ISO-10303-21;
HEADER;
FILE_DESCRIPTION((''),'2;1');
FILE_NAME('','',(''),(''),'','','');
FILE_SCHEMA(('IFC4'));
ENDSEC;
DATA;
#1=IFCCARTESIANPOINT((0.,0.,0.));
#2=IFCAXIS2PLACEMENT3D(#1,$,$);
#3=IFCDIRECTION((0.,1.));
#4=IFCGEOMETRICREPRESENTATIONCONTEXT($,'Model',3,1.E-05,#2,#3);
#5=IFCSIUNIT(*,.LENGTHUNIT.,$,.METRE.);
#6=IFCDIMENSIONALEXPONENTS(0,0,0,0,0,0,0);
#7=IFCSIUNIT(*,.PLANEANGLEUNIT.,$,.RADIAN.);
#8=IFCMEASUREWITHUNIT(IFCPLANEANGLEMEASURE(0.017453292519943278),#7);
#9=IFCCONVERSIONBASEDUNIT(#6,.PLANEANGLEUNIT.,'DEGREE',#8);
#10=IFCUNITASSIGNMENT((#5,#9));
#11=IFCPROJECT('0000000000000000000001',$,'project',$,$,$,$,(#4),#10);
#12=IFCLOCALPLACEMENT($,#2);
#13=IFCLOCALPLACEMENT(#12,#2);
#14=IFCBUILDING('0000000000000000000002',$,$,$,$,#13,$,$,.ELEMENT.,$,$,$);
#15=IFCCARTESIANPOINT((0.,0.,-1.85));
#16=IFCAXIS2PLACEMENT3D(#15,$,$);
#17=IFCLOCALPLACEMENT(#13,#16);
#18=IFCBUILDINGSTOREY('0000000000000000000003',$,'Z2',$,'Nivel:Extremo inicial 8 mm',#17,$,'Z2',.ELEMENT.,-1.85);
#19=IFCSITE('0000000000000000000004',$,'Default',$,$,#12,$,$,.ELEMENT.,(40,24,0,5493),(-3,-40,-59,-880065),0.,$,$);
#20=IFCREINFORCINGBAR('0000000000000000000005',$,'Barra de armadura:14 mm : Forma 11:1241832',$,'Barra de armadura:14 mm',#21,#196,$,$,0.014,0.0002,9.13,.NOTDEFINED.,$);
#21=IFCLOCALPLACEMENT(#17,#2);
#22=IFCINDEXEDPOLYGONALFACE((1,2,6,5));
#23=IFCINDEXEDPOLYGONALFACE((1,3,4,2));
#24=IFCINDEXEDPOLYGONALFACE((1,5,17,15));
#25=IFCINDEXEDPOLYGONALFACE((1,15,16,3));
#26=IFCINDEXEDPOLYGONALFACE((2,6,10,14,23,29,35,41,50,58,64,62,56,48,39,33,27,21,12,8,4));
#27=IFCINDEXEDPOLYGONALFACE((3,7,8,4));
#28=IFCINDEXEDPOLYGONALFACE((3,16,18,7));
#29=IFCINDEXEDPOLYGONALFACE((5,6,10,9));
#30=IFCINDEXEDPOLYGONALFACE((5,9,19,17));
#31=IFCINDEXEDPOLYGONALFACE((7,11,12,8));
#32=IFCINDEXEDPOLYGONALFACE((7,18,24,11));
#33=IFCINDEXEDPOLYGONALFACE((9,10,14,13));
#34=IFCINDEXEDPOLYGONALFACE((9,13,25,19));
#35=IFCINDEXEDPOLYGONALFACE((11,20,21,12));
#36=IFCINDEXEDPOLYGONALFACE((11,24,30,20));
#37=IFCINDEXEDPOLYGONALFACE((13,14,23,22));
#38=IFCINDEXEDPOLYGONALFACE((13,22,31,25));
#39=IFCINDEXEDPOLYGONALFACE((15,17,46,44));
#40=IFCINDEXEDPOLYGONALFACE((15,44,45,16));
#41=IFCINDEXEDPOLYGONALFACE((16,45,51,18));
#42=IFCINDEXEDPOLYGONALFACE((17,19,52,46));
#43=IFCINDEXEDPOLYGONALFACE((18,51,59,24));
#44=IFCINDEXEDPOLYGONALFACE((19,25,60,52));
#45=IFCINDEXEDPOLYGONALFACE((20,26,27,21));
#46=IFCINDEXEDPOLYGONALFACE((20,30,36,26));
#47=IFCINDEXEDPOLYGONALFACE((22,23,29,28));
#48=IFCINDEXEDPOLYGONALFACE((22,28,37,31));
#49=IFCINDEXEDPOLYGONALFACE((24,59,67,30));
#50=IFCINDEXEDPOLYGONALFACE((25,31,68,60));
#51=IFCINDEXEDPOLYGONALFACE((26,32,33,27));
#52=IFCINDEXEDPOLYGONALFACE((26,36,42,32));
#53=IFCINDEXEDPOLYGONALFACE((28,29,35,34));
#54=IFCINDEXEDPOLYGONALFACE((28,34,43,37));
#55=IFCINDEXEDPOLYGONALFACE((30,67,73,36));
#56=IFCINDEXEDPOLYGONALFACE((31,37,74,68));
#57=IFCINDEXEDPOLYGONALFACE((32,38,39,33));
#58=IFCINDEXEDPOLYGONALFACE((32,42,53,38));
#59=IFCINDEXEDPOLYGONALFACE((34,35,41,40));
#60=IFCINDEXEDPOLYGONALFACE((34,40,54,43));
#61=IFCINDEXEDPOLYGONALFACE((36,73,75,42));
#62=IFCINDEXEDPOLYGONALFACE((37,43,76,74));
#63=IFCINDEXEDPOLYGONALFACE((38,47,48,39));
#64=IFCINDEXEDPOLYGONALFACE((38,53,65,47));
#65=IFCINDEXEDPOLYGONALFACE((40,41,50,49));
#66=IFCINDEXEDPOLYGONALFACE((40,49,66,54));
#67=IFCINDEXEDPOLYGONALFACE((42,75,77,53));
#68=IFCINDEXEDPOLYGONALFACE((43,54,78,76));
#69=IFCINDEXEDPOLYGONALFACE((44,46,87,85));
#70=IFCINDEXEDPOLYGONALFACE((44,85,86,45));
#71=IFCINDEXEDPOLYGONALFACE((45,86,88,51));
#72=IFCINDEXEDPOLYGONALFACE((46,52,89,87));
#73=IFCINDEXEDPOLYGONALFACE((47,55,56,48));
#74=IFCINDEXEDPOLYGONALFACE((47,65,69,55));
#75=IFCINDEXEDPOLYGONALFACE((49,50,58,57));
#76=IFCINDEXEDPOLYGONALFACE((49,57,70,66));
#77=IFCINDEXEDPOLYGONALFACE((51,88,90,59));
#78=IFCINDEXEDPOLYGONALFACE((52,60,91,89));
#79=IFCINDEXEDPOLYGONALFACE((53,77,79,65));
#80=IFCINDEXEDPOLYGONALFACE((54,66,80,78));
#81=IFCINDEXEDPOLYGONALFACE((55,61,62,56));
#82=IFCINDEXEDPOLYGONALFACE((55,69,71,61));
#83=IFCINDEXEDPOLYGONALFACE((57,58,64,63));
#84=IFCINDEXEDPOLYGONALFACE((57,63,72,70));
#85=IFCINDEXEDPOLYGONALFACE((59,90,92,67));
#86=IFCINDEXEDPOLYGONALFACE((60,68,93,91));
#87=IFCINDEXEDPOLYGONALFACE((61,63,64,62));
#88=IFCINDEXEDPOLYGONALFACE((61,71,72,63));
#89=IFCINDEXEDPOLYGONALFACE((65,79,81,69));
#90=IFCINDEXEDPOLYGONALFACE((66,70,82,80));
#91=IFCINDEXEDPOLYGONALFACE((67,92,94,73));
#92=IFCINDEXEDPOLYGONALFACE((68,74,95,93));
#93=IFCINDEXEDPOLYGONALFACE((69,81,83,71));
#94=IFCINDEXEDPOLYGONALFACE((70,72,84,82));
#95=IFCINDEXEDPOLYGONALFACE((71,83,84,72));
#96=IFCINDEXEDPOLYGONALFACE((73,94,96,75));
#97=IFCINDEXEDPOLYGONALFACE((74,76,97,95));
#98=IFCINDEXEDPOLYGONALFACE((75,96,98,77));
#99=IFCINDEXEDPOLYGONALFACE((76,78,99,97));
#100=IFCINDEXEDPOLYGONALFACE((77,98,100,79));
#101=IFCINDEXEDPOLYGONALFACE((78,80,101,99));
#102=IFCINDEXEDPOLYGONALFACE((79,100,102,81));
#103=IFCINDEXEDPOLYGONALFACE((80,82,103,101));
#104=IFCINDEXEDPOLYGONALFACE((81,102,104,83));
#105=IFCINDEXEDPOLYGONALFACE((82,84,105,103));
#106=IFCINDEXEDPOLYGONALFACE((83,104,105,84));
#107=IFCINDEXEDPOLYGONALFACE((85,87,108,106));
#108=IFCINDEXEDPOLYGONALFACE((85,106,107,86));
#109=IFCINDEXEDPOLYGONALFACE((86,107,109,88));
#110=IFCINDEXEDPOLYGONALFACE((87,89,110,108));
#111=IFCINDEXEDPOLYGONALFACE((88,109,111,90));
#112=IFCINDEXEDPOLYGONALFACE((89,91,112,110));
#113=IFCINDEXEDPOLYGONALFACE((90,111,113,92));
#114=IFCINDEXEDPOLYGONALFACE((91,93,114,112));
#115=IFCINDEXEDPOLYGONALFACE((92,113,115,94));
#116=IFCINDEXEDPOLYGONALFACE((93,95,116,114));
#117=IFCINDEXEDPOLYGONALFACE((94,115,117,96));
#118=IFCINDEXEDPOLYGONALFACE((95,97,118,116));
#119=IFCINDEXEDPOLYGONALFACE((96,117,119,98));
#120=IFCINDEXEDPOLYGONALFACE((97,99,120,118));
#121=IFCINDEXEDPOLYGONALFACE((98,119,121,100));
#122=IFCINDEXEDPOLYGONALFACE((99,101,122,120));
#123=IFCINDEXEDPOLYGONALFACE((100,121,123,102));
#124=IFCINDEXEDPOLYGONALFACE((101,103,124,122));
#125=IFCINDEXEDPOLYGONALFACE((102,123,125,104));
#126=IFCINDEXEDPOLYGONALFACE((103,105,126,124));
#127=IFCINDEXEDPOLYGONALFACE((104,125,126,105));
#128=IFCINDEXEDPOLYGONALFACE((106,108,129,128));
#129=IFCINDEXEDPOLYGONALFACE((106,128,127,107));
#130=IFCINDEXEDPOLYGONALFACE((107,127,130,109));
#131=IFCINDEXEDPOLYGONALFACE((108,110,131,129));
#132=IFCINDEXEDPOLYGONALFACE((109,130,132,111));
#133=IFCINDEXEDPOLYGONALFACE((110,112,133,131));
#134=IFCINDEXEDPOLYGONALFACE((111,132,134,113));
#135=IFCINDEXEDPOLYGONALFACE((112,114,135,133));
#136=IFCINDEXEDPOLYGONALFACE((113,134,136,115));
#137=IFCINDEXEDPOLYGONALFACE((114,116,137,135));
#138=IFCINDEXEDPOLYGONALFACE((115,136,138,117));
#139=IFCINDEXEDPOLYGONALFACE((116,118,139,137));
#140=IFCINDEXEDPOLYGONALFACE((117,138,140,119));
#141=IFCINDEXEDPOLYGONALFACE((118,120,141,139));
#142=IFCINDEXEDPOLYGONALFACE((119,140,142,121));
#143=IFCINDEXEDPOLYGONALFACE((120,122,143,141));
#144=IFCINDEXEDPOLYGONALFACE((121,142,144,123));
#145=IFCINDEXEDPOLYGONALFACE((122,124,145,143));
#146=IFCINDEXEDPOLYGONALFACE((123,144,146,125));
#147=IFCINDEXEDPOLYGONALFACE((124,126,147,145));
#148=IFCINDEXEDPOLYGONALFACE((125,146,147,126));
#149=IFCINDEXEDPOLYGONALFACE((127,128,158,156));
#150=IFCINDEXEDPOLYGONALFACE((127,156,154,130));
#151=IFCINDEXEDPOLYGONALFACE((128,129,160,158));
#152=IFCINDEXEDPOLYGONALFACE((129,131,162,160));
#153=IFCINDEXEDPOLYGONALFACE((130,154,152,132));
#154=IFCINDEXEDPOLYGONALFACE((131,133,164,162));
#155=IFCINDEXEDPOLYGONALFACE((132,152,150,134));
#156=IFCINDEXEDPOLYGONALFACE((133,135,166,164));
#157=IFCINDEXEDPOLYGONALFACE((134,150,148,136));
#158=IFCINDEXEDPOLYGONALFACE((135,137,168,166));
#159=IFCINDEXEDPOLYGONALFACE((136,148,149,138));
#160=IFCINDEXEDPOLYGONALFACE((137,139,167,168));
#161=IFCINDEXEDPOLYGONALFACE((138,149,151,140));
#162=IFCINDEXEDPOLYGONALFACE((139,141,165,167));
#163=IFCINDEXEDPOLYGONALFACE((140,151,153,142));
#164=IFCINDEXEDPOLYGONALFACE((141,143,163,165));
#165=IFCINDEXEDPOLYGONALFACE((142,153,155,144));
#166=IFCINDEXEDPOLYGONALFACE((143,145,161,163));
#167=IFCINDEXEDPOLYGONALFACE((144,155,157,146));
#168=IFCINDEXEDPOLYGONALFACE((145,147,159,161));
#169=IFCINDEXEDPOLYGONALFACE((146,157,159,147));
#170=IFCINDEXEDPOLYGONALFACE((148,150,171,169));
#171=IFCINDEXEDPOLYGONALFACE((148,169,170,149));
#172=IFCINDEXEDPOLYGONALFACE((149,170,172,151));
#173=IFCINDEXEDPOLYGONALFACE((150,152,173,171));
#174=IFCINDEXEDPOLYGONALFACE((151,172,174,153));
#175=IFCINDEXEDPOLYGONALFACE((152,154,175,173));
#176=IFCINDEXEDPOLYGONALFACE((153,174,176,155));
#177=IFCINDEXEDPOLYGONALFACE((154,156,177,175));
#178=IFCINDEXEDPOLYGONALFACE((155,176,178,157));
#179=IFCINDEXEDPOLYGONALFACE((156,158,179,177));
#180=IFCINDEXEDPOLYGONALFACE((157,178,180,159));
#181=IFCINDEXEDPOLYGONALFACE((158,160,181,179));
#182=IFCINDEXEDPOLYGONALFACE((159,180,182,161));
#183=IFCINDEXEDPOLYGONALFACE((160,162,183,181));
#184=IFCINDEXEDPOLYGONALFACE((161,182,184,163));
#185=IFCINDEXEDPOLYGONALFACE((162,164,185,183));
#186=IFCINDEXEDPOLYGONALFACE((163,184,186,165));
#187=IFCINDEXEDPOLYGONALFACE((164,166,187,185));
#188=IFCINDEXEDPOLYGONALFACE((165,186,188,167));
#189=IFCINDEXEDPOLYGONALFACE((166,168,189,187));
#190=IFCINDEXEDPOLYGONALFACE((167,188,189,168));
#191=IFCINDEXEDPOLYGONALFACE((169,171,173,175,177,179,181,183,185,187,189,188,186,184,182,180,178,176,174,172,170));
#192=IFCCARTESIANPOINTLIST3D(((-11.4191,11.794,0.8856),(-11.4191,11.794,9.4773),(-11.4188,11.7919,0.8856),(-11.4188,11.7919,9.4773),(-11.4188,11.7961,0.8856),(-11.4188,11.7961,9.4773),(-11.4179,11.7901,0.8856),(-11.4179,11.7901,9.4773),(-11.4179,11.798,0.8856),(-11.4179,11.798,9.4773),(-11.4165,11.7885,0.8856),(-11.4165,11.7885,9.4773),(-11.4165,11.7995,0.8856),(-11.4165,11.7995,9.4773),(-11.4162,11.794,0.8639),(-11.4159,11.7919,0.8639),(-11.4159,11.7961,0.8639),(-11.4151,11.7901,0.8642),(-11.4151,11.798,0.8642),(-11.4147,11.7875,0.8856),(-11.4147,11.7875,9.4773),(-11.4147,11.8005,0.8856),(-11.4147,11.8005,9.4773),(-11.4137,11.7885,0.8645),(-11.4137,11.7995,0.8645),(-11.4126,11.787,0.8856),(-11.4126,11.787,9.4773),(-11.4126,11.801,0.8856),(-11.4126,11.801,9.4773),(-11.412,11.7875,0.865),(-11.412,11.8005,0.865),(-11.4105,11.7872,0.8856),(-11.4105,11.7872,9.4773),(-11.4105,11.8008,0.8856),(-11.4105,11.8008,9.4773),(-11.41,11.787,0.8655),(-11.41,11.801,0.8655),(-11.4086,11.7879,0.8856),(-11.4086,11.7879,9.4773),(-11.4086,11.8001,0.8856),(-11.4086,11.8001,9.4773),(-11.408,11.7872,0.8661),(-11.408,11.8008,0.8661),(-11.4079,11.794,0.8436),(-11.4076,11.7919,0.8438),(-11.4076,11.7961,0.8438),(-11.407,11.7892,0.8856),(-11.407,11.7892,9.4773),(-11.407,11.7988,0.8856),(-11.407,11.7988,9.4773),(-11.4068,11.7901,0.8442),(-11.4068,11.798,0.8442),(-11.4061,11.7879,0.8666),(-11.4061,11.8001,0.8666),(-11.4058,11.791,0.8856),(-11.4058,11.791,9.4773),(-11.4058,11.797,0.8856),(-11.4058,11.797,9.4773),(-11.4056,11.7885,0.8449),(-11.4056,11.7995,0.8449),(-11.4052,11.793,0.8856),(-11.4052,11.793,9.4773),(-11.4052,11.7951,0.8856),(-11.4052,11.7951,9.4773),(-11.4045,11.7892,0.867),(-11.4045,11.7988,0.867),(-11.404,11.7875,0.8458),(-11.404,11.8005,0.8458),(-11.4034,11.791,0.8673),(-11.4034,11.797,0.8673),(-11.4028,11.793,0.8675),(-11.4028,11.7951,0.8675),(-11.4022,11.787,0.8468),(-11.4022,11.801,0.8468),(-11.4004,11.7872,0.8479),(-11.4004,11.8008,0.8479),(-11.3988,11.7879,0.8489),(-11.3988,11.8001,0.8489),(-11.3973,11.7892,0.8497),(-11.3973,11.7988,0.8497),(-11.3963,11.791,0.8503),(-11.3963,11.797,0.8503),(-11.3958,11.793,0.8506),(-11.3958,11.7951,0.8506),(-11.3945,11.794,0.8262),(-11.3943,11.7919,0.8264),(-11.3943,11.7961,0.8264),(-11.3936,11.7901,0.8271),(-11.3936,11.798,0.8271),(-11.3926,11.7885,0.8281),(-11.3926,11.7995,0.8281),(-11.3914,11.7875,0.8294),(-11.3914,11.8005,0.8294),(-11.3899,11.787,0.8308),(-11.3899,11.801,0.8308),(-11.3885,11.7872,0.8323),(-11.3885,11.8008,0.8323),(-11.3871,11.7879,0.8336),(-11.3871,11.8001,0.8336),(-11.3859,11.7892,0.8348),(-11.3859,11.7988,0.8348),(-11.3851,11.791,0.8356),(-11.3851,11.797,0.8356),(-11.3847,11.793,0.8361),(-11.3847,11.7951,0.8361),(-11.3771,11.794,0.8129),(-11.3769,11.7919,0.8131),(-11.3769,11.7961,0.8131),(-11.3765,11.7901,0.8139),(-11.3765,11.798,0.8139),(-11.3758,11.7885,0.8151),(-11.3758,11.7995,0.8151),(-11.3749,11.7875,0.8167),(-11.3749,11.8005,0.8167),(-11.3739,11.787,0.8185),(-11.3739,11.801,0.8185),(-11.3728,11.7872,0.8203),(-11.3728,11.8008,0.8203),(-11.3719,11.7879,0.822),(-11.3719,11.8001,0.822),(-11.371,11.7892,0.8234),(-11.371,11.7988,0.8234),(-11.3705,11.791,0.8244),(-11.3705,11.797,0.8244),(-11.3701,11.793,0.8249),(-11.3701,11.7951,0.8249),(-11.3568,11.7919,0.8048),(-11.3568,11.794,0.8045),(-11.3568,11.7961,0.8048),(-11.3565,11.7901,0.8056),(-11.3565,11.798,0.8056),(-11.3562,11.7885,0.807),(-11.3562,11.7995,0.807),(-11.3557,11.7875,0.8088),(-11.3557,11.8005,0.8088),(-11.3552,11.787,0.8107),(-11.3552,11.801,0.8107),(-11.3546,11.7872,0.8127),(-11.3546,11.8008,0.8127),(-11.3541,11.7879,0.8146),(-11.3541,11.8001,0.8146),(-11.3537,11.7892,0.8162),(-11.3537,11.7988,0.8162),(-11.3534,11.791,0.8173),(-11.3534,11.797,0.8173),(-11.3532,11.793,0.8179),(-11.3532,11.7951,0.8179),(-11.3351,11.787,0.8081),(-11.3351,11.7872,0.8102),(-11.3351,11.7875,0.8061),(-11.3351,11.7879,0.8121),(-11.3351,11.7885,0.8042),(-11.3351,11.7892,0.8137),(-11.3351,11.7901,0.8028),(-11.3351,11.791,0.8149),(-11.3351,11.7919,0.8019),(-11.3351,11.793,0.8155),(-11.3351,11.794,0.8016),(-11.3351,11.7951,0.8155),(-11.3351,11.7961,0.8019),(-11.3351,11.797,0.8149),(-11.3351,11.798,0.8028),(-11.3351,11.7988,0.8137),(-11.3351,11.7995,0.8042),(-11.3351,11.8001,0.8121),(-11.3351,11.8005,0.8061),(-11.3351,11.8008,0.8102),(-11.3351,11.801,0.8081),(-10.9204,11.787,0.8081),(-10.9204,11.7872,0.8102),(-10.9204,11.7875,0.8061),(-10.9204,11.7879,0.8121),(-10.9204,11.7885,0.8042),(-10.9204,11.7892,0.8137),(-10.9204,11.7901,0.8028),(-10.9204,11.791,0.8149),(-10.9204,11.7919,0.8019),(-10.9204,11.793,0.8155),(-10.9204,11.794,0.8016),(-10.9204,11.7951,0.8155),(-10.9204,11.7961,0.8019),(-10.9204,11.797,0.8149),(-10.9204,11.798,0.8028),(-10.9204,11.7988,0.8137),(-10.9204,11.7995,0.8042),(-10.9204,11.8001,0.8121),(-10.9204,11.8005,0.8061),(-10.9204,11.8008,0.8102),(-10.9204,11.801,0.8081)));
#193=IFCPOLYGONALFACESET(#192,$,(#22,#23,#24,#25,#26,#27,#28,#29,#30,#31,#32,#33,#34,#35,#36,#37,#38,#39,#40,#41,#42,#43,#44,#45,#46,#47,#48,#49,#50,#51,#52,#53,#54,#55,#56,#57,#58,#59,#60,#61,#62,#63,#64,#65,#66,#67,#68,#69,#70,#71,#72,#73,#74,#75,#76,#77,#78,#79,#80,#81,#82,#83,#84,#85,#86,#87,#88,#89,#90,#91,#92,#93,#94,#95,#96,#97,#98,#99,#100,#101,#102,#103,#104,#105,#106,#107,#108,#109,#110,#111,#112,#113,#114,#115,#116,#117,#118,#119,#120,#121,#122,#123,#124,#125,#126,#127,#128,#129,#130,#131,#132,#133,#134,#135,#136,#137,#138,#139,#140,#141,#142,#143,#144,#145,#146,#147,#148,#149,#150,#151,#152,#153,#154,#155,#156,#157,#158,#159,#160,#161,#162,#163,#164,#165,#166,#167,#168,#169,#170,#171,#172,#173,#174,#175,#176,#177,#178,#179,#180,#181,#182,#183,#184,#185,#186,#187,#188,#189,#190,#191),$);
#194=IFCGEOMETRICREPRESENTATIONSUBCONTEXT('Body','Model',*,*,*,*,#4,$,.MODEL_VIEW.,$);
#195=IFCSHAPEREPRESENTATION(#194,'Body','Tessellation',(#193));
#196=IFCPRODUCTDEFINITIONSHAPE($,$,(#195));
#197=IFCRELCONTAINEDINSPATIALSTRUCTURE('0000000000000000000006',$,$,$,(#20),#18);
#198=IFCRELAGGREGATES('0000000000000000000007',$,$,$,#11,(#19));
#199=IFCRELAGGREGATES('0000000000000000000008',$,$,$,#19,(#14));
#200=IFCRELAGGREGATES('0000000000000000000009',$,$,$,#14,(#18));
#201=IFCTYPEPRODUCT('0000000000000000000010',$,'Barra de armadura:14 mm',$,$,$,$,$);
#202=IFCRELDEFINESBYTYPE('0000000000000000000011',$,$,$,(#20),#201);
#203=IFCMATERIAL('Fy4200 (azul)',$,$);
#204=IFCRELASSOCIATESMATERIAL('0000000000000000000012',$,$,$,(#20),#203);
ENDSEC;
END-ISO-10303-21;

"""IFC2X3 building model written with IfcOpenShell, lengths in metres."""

from ifc_helpers import new_model, entity, si_unit, converted_unit, direction, frame, origin, place, context, subcontext, project, spatial, material, type_object, element, save


model = new_model("IFC2X3")

# Units and contexts
model_context = context("Model", 3, precision=1e-05, world=origin(), true_north=direction((0.0, 1.0)))
body_context = subcontext(model_context, "Body", "Model", "MODEL_VIEW")
ifc_project = project(units=[si_unit("LENGTHUNIT", "METRE"), converted_unit("PLANEANGLEUNIT", "DEGREE", entity("IfcPlaneAngleMeasure", 0.017453292519943278), si_unit("PLANEANGLEUNIT", "RADIAN"), dimensions=[0, 0, 0, 0, 0, 0, 0])], contexts=[model_context])

# Site, building, storey
site_placement = place(None, origin())
site = spatial("IfcSite", under=ifc_project, at=site_placement, Name="Default", CompositionType="ELEMENT", RefLatitude=(40, 24, 0, 5493), RefLongitude=(-3, -40, -59, -880065), RefElevation=0.0)
building_placement = place(site_placement, origin())
building = spatial("IfcBuilding", under=site, at=building_placement, CompositionType="ELEMENT")
storey_placement = place(building_placement, frame((0.0, 0.0, -1.85)))
storey = spatial("IfcBuildingStorey", under=building, at=storey_placement, Name="Z2", ObjectType="Nivel:Extremo inicial 8 mm", LongName="Z2", CompositionType="ELEMENT", Elevation=-1.85)

# Reinforcing bar
ifc_material_1 = material(Name="Fy4200 (azul)")
type_product_1 = type_object("IfcTypeProduct", Name="Barra de armadura:14 mm")
reinforcing_bar_1_placement = place(storey_placement, origin())
element("IfcReinforcingBar", 1, at=reinforcing_bar_1_placement, inside=storey, type_object=type_product_1, material=ifc_material_1, Name="Barra de armadura:14 mm : Forma 11:1241832", ObjectType="Barra de armadura:14 mm", BarLength=9.13, BarRole="NOTDEFINED", CrossSectionArea=0.0002, NominalDiameter=0.014, context=body_context, shape_type="AdvancedSweptSolid", body=[
    entity("IfcSweptDiskSolid", entity("IfcCompositeCurve", [entity("IfcCompositeCurveSegment", "CONTINUOUS", True, entity("IfcPolyline", [entity("IfcCartesianPoint", [-11.4121, 11.794, 9.4773]), entity("IfcCartesianPoint", [-11.4121, 11.794, 0.8856])])), entity("IfcCompositeCurveSegment", "CONTINUOUS", True, entity("IfcTrimmedCurve", entity("IfcCircle", entity("IfcAxis2Placement3D", entity("IfcCartesianPoint", [-11.3351, 11.794, 0.8856]), entity("IfcDirection", [0.0, -1.0, 0.0]), entity("IfcDirection", [0.0, 0.0, -1.0])), 0.077), [entity("IfcParameterValue", 270.0)], [entity("IfcParameterValue", 360.0)], True, "PARAMETER")), entity("IfcCompositeCurveSegment", "CONTINUOUS", True, entity("IfcPolyline", [entity("IfcCartesianPoint", [-11.3351, 11.794, 0.8086]), entity("IfcCartesianPoint", [-10.9204, 11.794, 0.8086])]))], False), 0.007, None, 0.0, 92.0),
])

save(model, "model.ifc")
